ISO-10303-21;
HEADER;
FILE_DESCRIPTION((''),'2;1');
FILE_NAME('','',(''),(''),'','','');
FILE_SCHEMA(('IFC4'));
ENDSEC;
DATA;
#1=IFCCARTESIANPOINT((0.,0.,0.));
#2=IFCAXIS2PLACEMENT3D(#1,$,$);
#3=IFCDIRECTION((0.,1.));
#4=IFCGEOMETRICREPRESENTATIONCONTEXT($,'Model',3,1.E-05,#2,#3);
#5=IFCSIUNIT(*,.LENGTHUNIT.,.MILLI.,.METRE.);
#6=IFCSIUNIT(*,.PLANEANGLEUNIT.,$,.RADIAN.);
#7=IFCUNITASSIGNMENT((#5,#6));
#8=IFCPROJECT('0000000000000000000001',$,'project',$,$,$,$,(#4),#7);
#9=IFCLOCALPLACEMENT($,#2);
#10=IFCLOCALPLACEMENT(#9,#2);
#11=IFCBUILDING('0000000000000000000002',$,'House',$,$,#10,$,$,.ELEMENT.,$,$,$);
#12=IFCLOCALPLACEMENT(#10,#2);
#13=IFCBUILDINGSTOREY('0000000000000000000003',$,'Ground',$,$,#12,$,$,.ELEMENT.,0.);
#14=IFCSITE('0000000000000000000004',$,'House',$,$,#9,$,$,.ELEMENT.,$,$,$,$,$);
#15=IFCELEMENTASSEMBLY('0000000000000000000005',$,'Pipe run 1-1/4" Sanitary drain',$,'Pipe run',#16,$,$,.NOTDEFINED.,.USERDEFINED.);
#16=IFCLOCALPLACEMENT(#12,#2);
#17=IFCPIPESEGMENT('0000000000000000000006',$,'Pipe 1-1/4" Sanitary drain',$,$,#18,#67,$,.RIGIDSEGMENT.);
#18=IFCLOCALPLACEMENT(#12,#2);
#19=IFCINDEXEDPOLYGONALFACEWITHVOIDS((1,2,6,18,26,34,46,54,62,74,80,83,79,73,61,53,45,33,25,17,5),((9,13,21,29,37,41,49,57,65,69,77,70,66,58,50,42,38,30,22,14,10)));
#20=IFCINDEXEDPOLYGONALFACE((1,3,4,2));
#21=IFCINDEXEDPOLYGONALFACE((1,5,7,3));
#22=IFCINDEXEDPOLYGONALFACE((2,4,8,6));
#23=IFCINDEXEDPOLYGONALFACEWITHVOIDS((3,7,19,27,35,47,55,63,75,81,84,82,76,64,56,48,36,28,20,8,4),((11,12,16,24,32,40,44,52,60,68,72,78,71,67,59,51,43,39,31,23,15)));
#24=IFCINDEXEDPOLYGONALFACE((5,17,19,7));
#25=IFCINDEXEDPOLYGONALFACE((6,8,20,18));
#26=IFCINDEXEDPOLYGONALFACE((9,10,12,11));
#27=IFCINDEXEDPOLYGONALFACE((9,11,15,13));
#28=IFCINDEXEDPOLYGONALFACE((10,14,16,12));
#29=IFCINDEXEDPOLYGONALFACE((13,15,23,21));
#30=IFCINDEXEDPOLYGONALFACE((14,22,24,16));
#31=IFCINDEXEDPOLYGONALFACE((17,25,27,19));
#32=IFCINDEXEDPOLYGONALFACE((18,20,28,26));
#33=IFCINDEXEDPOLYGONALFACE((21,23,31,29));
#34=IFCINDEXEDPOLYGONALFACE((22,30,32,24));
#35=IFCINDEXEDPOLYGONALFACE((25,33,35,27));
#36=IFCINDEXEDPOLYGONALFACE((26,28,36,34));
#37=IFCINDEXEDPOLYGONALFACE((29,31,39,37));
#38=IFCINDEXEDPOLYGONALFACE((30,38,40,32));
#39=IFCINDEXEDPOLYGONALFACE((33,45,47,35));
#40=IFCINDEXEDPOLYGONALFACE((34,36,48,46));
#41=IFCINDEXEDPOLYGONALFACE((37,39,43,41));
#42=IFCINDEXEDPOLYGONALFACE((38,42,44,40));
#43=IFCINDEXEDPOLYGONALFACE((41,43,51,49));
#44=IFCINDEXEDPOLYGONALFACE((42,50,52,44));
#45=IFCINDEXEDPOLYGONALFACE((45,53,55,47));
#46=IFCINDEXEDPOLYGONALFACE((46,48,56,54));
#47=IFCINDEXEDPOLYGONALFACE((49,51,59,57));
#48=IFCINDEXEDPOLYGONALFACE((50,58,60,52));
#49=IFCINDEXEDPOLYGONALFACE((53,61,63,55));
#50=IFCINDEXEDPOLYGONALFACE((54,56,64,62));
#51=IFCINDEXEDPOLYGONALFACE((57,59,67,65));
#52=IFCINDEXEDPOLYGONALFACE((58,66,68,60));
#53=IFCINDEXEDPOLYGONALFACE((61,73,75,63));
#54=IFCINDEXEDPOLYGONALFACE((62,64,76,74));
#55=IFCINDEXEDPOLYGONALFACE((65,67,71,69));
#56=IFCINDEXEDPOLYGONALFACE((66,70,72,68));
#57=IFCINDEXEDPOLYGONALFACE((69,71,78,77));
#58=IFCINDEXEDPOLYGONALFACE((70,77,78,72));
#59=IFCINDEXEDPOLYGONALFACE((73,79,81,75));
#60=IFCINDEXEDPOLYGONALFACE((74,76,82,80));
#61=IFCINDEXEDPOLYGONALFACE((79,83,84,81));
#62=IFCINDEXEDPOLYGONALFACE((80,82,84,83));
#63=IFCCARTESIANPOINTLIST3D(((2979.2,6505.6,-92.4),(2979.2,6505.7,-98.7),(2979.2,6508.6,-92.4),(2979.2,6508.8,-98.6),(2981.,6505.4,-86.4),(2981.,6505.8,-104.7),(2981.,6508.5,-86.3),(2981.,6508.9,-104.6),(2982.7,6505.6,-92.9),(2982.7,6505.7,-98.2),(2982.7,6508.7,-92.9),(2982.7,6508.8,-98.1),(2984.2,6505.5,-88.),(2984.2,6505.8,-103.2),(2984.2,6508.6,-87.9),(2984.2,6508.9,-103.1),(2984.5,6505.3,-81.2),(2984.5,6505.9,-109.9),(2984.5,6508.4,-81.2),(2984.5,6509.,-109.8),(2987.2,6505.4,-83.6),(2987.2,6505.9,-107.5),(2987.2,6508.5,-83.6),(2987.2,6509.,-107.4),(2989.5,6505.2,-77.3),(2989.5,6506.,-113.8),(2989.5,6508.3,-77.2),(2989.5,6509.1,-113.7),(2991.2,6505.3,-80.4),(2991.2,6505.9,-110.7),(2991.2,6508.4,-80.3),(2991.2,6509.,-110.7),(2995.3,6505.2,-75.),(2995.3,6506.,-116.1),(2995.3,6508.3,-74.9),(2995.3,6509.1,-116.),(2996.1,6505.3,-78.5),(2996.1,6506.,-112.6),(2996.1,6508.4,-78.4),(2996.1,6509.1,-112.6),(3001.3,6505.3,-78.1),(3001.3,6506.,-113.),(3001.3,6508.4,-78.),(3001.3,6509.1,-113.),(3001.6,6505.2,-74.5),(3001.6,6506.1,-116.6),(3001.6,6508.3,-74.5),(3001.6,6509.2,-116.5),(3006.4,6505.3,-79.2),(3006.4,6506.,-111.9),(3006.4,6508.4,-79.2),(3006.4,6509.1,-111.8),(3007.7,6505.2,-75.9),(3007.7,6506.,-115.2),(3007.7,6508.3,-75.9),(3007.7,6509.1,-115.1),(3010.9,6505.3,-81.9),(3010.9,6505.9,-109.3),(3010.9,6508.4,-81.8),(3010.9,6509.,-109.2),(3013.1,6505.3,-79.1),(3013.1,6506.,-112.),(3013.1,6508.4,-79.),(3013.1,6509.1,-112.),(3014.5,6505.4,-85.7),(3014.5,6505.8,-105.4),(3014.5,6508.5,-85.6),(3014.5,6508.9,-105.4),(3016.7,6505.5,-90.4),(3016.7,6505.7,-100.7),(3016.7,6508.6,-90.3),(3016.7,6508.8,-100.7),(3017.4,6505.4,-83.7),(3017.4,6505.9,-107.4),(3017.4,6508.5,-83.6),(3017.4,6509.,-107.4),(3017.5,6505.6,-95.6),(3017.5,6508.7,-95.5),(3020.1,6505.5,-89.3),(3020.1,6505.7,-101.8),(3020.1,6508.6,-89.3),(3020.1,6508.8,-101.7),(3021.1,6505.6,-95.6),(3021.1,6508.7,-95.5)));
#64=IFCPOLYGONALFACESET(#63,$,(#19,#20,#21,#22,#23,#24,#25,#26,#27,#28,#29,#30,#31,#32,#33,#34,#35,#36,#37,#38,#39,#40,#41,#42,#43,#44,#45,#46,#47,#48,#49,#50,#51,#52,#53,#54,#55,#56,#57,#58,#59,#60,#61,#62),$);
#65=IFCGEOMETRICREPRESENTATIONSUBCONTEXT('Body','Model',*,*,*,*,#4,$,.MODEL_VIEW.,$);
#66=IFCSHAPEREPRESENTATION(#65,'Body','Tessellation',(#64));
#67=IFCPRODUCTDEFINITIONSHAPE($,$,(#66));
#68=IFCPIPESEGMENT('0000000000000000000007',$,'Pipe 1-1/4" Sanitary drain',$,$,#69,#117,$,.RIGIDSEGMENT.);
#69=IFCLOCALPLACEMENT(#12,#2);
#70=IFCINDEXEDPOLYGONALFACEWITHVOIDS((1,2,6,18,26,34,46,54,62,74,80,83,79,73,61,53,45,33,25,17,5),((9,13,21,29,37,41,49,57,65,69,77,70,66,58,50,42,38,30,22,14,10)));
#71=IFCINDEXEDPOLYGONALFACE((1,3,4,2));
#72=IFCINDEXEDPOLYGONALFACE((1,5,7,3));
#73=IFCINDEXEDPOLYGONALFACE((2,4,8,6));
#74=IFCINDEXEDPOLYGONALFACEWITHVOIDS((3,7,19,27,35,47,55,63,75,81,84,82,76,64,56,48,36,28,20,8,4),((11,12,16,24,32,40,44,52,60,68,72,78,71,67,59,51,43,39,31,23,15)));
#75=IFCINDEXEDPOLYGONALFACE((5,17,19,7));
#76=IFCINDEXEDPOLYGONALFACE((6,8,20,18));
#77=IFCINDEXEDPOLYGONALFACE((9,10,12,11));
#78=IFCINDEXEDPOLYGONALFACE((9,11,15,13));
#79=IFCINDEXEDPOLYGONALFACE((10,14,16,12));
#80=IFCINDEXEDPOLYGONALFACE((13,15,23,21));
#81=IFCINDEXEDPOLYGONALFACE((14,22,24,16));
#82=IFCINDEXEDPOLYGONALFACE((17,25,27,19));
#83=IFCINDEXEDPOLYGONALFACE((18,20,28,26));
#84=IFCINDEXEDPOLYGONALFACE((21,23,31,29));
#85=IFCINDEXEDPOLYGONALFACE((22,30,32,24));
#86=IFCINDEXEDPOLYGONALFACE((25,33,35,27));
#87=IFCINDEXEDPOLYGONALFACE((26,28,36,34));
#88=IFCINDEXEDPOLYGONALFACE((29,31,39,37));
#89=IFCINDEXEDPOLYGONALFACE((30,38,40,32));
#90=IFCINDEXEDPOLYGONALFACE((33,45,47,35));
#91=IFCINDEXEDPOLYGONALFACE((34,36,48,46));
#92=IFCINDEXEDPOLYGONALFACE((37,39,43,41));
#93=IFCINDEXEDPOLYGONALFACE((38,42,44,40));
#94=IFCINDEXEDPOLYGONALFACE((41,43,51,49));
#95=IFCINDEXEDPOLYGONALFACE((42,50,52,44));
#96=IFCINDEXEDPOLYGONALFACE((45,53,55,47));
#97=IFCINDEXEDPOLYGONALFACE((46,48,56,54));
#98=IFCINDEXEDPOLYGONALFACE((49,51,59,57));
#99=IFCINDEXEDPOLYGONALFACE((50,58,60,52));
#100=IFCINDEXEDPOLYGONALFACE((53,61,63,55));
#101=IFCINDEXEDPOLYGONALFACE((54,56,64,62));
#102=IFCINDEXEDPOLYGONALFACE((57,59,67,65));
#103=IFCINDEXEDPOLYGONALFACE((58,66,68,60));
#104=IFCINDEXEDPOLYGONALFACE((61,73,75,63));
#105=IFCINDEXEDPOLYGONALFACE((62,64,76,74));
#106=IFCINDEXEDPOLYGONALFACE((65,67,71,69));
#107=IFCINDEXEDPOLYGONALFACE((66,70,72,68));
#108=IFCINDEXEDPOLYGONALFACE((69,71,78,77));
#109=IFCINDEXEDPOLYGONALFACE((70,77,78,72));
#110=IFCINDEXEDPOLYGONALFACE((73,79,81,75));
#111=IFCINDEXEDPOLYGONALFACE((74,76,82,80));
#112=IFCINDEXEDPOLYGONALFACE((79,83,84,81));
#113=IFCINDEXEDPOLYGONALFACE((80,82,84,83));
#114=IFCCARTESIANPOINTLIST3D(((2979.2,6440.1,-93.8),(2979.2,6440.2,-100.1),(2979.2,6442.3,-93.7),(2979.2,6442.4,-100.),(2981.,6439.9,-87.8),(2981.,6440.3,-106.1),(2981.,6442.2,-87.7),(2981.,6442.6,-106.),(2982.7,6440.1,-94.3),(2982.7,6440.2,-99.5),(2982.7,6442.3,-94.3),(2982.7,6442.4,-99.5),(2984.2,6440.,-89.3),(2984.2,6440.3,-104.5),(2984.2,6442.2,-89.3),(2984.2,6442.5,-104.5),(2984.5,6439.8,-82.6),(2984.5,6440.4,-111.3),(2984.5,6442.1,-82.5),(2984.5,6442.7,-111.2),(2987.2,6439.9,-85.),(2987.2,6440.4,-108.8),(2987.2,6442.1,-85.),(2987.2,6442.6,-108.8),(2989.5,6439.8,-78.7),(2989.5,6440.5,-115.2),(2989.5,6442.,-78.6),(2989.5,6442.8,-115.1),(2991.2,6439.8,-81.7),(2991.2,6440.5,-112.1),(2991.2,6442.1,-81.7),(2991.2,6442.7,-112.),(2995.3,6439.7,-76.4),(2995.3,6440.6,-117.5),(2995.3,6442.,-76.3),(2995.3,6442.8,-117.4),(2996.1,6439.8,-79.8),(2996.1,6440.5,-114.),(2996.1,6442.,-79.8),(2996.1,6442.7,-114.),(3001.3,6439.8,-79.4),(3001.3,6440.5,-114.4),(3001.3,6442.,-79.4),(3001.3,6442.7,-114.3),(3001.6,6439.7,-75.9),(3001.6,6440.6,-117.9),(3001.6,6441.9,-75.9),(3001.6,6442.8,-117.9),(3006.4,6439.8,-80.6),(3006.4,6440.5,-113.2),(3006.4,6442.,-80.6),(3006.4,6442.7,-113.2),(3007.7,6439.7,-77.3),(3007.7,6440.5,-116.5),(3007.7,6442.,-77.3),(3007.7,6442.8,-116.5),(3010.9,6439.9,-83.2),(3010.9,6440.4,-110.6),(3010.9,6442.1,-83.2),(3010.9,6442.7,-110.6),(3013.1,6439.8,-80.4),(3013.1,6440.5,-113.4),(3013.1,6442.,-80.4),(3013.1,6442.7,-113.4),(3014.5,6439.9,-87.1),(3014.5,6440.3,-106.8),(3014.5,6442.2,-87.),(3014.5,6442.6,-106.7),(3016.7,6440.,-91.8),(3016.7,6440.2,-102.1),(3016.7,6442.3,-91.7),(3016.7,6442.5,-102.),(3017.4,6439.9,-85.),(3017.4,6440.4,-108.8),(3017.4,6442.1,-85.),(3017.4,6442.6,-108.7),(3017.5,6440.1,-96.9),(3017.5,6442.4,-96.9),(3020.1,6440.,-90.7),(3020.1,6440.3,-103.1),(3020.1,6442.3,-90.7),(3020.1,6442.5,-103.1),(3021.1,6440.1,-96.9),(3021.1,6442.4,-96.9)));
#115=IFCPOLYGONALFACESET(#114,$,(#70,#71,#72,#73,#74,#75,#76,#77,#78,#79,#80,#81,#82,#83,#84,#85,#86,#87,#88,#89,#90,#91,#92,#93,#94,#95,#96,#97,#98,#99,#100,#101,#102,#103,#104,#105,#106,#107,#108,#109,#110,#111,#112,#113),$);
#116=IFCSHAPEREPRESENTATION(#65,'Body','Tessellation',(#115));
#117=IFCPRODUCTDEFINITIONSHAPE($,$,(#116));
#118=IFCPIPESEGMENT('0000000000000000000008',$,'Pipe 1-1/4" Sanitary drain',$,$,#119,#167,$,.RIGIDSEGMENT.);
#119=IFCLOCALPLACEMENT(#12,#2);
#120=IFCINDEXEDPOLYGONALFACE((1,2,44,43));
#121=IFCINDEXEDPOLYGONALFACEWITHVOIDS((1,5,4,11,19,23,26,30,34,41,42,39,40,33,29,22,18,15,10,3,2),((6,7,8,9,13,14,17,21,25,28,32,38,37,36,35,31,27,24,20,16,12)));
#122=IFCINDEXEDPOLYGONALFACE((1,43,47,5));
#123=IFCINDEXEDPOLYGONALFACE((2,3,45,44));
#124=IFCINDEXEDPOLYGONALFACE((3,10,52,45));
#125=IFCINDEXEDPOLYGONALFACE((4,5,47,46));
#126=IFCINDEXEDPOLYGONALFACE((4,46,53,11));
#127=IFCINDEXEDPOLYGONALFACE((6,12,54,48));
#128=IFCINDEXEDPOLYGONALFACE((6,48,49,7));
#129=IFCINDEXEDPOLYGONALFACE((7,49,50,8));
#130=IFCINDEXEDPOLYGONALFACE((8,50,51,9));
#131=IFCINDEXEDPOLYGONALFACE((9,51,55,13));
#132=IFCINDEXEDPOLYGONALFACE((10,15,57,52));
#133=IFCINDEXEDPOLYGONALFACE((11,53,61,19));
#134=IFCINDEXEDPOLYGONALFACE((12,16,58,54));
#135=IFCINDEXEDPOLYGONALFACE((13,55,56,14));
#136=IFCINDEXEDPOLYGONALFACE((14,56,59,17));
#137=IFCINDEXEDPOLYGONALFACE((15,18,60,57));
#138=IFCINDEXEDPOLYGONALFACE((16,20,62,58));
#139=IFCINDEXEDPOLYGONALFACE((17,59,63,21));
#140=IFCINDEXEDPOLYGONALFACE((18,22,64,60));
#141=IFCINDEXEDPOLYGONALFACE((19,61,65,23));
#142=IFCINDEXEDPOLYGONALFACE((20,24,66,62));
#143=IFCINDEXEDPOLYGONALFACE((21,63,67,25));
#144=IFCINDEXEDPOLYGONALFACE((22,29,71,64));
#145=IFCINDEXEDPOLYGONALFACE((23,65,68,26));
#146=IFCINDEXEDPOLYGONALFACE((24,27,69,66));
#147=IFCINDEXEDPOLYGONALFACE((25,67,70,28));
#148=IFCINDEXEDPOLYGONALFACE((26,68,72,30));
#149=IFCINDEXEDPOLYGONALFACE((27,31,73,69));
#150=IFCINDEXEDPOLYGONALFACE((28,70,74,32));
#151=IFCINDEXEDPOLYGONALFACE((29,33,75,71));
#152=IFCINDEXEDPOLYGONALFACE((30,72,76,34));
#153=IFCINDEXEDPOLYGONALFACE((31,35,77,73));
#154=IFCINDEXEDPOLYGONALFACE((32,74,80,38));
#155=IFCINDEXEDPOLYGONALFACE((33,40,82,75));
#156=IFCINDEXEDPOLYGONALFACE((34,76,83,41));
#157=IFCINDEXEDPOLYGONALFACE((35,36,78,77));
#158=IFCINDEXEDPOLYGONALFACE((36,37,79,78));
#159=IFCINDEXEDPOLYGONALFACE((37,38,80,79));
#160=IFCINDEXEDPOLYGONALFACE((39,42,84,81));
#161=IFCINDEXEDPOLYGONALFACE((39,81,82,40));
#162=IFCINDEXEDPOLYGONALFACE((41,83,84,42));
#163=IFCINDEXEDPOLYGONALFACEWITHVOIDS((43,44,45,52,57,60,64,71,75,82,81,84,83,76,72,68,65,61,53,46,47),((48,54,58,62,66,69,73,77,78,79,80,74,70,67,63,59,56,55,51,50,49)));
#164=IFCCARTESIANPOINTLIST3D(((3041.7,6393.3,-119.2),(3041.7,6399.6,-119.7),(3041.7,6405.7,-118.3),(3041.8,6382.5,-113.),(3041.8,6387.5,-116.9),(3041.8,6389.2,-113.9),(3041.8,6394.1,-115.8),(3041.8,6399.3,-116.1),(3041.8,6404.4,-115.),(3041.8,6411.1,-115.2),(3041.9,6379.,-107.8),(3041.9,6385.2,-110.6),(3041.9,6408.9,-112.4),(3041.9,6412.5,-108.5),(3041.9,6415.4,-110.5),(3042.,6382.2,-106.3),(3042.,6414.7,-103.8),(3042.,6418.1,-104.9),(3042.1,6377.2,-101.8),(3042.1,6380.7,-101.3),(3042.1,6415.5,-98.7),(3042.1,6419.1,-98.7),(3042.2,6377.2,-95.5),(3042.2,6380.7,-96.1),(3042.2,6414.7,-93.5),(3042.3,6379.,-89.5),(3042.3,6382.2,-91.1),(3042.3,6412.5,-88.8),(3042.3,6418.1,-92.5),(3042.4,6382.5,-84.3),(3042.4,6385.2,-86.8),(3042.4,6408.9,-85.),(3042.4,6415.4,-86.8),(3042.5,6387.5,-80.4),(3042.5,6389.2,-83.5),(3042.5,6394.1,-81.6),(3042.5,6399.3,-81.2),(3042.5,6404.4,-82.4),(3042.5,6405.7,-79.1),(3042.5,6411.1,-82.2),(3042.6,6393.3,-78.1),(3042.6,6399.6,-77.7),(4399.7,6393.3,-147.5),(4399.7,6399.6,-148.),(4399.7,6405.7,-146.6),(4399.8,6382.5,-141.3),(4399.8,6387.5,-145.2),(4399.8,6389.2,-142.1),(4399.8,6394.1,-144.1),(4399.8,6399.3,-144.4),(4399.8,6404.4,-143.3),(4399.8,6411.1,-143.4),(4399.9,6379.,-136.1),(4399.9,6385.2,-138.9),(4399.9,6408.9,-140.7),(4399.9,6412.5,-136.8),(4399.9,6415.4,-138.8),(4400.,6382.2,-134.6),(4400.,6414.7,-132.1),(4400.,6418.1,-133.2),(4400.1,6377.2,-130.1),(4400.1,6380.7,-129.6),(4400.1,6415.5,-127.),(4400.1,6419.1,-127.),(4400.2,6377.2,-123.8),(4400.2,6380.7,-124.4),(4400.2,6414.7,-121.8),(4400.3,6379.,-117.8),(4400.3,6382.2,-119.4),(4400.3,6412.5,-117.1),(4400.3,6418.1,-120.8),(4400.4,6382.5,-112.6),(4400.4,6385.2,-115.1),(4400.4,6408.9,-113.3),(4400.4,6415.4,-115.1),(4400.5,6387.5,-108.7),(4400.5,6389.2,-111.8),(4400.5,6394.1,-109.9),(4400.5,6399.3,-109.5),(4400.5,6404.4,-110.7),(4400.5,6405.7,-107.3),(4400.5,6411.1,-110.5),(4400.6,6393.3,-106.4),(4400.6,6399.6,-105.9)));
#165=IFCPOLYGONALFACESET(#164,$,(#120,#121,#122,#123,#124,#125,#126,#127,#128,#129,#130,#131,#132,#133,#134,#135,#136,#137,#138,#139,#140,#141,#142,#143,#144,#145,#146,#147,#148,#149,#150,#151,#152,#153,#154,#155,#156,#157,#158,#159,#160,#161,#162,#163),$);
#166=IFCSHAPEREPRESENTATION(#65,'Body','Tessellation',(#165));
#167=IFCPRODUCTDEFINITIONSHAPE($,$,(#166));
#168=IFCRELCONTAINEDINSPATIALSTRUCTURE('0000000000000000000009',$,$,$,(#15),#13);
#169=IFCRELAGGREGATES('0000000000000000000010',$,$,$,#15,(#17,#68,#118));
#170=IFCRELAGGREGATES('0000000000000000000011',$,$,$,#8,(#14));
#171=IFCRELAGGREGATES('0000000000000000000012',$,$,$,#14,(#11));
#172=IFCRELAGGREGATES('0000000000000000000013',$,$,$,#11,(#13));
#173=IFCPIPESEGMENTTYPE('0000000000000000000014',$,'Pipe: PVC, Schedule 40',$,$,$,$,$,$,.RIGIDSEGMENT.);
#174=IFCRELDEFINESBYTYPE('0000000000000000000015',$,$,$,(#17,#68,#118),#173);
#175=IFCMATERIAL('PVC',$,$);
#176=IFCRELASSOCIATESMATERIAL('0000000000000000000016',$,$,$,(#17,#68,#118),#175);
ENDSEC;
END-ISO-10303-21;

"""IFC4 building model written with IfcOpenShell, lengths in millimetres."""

from ifc_helpers import new_model, si_unit, direction, frame, origin, origin_with_axes, origin_2d, place, context, subcontext, project, spatial, hollow_circle, extrude, material, type_object, element, aggregate, save


model = new_model("IFC4")

# Units and contexts
model_context = context("Model", 3, precision=1e-05, world=origin(), true_north=direction((0.0, 1.0)))
body_context = subcontext(model_context, "Body", "Model", "MODEL_VIEW")
ifc_project = project(units=[si_unit("LENGTHUNIT", "METRE", prefix="MILLI"), si_unit("PLANEANGLEUNIT", "RADIAN")], contexts=[model_context])

# Site, building, storey
site_placement = place(None, origin())
site = spatial("IfcSite", under=ifc_project, at=site_placement, Name="House", CompositionType="ELEMENT")
building_placement = place(site_placement, origin())
building = spatial("IfcBuilding", under=site, at=building_placement, Name="House", CompositionType="ELEMENT")
storey_placement = place(building_placement, origin())
storey = spatial("IfcBuildingStorey", under=building, at=storey_placement, Name="Ground", CompositionType="ELEMENT", Elevation=0.0)

# Shared definitions
ifc_material = material(Name="PVC")
pipe_segment_type = type_object("IfcPipeSegmentType", Name="Pipe: PVC, Schedule 40", PredefinedType="RIGIDSEGMENT")

# Element assembly, pipe segments
assembly_1_placement = place(storey_placement, origin_with_axes())
assembly_1 = element("IfcElementAssembly", 1, at=assembly_1_placement, inside=storey, Name="Pipe run 1-1/4\" Sanitary drain", ObjectType="Pipe run", AssemblyPlace="NOTDEFINED", PredefinedType="USERDEFINED")
pipe_segment_1_placement = place(storey_placement, origin_with_axes())
pipe_segment_1 = element("IfcPipeSegment", 2, at=pipe_segment_1_placement, type_object=pipe_segment_type, material=ifc_material, Name="Pipe 1-1/4\" Sanitary drain", PredefinedType="RIGIDSEGMENT", context=body_context, shape_type="SweptSolid", body=[
    extrude(hollow_circle(Radius=21.1, WallThickness=3.6, at=origin_2d()), frame((3000.0, 6508.7, -95.5), z_axis=(0.0, -0.999783, -0.020829), x_axis=(1.0, 0.0, 0.0)), (0.0, 0.0, 1.0), 3.1),
])
pipe_segment_2_placement = place(storey_placement, origin_with_axes())
pipe_segment_2 = element("IfcPipeSegment", 3, at=pipe_segment_2_placement, type_object=pipe_segment_type, material=ifc_material, Name="Pipe 1-1/4\" Sanitary drain", PredefinedType="RIGIDSEGMENT", context=body_context, shape_type="SweptSolid", body=[
    extrude(hollow_circle(Radius=21.1, WallThickness=3.6, at=origin_2d()), frame((3000.0, 6442.4, -96.9), z_axis=(0.0, -0.999783, -0.020829), x_axis=(1.0, 0.0, 0.0)), (0.0, 0.0, 1.0), 2.2),
])
pipe_segment_3_placement = place(storey_placement, origin_with_axes())
pipe_segment_3 = element("IfcPipeSegment", 4, at=pipe_segment_3_placement, type_object=pipe_segment_type, material=ifc_material, Name="Pipe 1-1/4\" Sanitary drain", PredefinedType="RIGIDSEGMENT", context=body_context, shape_type="SweptSolid", body=[
    extrude(hollow_circle(Radius=21.1, WallThickness=3.6, at=origin_2d()), frame((3042.1, 6398.0, -98.7), z_axis=(0.999783, 0.0, -0.020829), x_axis=(0.0, 1.0, 0.0)), (0.0, 0.0, 1.0), 1358.3),
])

aggregate(assembly_1, [pipe_segment_1, pipe_segment_2, pipe_segment_3])

save(model, "model.ifc")
